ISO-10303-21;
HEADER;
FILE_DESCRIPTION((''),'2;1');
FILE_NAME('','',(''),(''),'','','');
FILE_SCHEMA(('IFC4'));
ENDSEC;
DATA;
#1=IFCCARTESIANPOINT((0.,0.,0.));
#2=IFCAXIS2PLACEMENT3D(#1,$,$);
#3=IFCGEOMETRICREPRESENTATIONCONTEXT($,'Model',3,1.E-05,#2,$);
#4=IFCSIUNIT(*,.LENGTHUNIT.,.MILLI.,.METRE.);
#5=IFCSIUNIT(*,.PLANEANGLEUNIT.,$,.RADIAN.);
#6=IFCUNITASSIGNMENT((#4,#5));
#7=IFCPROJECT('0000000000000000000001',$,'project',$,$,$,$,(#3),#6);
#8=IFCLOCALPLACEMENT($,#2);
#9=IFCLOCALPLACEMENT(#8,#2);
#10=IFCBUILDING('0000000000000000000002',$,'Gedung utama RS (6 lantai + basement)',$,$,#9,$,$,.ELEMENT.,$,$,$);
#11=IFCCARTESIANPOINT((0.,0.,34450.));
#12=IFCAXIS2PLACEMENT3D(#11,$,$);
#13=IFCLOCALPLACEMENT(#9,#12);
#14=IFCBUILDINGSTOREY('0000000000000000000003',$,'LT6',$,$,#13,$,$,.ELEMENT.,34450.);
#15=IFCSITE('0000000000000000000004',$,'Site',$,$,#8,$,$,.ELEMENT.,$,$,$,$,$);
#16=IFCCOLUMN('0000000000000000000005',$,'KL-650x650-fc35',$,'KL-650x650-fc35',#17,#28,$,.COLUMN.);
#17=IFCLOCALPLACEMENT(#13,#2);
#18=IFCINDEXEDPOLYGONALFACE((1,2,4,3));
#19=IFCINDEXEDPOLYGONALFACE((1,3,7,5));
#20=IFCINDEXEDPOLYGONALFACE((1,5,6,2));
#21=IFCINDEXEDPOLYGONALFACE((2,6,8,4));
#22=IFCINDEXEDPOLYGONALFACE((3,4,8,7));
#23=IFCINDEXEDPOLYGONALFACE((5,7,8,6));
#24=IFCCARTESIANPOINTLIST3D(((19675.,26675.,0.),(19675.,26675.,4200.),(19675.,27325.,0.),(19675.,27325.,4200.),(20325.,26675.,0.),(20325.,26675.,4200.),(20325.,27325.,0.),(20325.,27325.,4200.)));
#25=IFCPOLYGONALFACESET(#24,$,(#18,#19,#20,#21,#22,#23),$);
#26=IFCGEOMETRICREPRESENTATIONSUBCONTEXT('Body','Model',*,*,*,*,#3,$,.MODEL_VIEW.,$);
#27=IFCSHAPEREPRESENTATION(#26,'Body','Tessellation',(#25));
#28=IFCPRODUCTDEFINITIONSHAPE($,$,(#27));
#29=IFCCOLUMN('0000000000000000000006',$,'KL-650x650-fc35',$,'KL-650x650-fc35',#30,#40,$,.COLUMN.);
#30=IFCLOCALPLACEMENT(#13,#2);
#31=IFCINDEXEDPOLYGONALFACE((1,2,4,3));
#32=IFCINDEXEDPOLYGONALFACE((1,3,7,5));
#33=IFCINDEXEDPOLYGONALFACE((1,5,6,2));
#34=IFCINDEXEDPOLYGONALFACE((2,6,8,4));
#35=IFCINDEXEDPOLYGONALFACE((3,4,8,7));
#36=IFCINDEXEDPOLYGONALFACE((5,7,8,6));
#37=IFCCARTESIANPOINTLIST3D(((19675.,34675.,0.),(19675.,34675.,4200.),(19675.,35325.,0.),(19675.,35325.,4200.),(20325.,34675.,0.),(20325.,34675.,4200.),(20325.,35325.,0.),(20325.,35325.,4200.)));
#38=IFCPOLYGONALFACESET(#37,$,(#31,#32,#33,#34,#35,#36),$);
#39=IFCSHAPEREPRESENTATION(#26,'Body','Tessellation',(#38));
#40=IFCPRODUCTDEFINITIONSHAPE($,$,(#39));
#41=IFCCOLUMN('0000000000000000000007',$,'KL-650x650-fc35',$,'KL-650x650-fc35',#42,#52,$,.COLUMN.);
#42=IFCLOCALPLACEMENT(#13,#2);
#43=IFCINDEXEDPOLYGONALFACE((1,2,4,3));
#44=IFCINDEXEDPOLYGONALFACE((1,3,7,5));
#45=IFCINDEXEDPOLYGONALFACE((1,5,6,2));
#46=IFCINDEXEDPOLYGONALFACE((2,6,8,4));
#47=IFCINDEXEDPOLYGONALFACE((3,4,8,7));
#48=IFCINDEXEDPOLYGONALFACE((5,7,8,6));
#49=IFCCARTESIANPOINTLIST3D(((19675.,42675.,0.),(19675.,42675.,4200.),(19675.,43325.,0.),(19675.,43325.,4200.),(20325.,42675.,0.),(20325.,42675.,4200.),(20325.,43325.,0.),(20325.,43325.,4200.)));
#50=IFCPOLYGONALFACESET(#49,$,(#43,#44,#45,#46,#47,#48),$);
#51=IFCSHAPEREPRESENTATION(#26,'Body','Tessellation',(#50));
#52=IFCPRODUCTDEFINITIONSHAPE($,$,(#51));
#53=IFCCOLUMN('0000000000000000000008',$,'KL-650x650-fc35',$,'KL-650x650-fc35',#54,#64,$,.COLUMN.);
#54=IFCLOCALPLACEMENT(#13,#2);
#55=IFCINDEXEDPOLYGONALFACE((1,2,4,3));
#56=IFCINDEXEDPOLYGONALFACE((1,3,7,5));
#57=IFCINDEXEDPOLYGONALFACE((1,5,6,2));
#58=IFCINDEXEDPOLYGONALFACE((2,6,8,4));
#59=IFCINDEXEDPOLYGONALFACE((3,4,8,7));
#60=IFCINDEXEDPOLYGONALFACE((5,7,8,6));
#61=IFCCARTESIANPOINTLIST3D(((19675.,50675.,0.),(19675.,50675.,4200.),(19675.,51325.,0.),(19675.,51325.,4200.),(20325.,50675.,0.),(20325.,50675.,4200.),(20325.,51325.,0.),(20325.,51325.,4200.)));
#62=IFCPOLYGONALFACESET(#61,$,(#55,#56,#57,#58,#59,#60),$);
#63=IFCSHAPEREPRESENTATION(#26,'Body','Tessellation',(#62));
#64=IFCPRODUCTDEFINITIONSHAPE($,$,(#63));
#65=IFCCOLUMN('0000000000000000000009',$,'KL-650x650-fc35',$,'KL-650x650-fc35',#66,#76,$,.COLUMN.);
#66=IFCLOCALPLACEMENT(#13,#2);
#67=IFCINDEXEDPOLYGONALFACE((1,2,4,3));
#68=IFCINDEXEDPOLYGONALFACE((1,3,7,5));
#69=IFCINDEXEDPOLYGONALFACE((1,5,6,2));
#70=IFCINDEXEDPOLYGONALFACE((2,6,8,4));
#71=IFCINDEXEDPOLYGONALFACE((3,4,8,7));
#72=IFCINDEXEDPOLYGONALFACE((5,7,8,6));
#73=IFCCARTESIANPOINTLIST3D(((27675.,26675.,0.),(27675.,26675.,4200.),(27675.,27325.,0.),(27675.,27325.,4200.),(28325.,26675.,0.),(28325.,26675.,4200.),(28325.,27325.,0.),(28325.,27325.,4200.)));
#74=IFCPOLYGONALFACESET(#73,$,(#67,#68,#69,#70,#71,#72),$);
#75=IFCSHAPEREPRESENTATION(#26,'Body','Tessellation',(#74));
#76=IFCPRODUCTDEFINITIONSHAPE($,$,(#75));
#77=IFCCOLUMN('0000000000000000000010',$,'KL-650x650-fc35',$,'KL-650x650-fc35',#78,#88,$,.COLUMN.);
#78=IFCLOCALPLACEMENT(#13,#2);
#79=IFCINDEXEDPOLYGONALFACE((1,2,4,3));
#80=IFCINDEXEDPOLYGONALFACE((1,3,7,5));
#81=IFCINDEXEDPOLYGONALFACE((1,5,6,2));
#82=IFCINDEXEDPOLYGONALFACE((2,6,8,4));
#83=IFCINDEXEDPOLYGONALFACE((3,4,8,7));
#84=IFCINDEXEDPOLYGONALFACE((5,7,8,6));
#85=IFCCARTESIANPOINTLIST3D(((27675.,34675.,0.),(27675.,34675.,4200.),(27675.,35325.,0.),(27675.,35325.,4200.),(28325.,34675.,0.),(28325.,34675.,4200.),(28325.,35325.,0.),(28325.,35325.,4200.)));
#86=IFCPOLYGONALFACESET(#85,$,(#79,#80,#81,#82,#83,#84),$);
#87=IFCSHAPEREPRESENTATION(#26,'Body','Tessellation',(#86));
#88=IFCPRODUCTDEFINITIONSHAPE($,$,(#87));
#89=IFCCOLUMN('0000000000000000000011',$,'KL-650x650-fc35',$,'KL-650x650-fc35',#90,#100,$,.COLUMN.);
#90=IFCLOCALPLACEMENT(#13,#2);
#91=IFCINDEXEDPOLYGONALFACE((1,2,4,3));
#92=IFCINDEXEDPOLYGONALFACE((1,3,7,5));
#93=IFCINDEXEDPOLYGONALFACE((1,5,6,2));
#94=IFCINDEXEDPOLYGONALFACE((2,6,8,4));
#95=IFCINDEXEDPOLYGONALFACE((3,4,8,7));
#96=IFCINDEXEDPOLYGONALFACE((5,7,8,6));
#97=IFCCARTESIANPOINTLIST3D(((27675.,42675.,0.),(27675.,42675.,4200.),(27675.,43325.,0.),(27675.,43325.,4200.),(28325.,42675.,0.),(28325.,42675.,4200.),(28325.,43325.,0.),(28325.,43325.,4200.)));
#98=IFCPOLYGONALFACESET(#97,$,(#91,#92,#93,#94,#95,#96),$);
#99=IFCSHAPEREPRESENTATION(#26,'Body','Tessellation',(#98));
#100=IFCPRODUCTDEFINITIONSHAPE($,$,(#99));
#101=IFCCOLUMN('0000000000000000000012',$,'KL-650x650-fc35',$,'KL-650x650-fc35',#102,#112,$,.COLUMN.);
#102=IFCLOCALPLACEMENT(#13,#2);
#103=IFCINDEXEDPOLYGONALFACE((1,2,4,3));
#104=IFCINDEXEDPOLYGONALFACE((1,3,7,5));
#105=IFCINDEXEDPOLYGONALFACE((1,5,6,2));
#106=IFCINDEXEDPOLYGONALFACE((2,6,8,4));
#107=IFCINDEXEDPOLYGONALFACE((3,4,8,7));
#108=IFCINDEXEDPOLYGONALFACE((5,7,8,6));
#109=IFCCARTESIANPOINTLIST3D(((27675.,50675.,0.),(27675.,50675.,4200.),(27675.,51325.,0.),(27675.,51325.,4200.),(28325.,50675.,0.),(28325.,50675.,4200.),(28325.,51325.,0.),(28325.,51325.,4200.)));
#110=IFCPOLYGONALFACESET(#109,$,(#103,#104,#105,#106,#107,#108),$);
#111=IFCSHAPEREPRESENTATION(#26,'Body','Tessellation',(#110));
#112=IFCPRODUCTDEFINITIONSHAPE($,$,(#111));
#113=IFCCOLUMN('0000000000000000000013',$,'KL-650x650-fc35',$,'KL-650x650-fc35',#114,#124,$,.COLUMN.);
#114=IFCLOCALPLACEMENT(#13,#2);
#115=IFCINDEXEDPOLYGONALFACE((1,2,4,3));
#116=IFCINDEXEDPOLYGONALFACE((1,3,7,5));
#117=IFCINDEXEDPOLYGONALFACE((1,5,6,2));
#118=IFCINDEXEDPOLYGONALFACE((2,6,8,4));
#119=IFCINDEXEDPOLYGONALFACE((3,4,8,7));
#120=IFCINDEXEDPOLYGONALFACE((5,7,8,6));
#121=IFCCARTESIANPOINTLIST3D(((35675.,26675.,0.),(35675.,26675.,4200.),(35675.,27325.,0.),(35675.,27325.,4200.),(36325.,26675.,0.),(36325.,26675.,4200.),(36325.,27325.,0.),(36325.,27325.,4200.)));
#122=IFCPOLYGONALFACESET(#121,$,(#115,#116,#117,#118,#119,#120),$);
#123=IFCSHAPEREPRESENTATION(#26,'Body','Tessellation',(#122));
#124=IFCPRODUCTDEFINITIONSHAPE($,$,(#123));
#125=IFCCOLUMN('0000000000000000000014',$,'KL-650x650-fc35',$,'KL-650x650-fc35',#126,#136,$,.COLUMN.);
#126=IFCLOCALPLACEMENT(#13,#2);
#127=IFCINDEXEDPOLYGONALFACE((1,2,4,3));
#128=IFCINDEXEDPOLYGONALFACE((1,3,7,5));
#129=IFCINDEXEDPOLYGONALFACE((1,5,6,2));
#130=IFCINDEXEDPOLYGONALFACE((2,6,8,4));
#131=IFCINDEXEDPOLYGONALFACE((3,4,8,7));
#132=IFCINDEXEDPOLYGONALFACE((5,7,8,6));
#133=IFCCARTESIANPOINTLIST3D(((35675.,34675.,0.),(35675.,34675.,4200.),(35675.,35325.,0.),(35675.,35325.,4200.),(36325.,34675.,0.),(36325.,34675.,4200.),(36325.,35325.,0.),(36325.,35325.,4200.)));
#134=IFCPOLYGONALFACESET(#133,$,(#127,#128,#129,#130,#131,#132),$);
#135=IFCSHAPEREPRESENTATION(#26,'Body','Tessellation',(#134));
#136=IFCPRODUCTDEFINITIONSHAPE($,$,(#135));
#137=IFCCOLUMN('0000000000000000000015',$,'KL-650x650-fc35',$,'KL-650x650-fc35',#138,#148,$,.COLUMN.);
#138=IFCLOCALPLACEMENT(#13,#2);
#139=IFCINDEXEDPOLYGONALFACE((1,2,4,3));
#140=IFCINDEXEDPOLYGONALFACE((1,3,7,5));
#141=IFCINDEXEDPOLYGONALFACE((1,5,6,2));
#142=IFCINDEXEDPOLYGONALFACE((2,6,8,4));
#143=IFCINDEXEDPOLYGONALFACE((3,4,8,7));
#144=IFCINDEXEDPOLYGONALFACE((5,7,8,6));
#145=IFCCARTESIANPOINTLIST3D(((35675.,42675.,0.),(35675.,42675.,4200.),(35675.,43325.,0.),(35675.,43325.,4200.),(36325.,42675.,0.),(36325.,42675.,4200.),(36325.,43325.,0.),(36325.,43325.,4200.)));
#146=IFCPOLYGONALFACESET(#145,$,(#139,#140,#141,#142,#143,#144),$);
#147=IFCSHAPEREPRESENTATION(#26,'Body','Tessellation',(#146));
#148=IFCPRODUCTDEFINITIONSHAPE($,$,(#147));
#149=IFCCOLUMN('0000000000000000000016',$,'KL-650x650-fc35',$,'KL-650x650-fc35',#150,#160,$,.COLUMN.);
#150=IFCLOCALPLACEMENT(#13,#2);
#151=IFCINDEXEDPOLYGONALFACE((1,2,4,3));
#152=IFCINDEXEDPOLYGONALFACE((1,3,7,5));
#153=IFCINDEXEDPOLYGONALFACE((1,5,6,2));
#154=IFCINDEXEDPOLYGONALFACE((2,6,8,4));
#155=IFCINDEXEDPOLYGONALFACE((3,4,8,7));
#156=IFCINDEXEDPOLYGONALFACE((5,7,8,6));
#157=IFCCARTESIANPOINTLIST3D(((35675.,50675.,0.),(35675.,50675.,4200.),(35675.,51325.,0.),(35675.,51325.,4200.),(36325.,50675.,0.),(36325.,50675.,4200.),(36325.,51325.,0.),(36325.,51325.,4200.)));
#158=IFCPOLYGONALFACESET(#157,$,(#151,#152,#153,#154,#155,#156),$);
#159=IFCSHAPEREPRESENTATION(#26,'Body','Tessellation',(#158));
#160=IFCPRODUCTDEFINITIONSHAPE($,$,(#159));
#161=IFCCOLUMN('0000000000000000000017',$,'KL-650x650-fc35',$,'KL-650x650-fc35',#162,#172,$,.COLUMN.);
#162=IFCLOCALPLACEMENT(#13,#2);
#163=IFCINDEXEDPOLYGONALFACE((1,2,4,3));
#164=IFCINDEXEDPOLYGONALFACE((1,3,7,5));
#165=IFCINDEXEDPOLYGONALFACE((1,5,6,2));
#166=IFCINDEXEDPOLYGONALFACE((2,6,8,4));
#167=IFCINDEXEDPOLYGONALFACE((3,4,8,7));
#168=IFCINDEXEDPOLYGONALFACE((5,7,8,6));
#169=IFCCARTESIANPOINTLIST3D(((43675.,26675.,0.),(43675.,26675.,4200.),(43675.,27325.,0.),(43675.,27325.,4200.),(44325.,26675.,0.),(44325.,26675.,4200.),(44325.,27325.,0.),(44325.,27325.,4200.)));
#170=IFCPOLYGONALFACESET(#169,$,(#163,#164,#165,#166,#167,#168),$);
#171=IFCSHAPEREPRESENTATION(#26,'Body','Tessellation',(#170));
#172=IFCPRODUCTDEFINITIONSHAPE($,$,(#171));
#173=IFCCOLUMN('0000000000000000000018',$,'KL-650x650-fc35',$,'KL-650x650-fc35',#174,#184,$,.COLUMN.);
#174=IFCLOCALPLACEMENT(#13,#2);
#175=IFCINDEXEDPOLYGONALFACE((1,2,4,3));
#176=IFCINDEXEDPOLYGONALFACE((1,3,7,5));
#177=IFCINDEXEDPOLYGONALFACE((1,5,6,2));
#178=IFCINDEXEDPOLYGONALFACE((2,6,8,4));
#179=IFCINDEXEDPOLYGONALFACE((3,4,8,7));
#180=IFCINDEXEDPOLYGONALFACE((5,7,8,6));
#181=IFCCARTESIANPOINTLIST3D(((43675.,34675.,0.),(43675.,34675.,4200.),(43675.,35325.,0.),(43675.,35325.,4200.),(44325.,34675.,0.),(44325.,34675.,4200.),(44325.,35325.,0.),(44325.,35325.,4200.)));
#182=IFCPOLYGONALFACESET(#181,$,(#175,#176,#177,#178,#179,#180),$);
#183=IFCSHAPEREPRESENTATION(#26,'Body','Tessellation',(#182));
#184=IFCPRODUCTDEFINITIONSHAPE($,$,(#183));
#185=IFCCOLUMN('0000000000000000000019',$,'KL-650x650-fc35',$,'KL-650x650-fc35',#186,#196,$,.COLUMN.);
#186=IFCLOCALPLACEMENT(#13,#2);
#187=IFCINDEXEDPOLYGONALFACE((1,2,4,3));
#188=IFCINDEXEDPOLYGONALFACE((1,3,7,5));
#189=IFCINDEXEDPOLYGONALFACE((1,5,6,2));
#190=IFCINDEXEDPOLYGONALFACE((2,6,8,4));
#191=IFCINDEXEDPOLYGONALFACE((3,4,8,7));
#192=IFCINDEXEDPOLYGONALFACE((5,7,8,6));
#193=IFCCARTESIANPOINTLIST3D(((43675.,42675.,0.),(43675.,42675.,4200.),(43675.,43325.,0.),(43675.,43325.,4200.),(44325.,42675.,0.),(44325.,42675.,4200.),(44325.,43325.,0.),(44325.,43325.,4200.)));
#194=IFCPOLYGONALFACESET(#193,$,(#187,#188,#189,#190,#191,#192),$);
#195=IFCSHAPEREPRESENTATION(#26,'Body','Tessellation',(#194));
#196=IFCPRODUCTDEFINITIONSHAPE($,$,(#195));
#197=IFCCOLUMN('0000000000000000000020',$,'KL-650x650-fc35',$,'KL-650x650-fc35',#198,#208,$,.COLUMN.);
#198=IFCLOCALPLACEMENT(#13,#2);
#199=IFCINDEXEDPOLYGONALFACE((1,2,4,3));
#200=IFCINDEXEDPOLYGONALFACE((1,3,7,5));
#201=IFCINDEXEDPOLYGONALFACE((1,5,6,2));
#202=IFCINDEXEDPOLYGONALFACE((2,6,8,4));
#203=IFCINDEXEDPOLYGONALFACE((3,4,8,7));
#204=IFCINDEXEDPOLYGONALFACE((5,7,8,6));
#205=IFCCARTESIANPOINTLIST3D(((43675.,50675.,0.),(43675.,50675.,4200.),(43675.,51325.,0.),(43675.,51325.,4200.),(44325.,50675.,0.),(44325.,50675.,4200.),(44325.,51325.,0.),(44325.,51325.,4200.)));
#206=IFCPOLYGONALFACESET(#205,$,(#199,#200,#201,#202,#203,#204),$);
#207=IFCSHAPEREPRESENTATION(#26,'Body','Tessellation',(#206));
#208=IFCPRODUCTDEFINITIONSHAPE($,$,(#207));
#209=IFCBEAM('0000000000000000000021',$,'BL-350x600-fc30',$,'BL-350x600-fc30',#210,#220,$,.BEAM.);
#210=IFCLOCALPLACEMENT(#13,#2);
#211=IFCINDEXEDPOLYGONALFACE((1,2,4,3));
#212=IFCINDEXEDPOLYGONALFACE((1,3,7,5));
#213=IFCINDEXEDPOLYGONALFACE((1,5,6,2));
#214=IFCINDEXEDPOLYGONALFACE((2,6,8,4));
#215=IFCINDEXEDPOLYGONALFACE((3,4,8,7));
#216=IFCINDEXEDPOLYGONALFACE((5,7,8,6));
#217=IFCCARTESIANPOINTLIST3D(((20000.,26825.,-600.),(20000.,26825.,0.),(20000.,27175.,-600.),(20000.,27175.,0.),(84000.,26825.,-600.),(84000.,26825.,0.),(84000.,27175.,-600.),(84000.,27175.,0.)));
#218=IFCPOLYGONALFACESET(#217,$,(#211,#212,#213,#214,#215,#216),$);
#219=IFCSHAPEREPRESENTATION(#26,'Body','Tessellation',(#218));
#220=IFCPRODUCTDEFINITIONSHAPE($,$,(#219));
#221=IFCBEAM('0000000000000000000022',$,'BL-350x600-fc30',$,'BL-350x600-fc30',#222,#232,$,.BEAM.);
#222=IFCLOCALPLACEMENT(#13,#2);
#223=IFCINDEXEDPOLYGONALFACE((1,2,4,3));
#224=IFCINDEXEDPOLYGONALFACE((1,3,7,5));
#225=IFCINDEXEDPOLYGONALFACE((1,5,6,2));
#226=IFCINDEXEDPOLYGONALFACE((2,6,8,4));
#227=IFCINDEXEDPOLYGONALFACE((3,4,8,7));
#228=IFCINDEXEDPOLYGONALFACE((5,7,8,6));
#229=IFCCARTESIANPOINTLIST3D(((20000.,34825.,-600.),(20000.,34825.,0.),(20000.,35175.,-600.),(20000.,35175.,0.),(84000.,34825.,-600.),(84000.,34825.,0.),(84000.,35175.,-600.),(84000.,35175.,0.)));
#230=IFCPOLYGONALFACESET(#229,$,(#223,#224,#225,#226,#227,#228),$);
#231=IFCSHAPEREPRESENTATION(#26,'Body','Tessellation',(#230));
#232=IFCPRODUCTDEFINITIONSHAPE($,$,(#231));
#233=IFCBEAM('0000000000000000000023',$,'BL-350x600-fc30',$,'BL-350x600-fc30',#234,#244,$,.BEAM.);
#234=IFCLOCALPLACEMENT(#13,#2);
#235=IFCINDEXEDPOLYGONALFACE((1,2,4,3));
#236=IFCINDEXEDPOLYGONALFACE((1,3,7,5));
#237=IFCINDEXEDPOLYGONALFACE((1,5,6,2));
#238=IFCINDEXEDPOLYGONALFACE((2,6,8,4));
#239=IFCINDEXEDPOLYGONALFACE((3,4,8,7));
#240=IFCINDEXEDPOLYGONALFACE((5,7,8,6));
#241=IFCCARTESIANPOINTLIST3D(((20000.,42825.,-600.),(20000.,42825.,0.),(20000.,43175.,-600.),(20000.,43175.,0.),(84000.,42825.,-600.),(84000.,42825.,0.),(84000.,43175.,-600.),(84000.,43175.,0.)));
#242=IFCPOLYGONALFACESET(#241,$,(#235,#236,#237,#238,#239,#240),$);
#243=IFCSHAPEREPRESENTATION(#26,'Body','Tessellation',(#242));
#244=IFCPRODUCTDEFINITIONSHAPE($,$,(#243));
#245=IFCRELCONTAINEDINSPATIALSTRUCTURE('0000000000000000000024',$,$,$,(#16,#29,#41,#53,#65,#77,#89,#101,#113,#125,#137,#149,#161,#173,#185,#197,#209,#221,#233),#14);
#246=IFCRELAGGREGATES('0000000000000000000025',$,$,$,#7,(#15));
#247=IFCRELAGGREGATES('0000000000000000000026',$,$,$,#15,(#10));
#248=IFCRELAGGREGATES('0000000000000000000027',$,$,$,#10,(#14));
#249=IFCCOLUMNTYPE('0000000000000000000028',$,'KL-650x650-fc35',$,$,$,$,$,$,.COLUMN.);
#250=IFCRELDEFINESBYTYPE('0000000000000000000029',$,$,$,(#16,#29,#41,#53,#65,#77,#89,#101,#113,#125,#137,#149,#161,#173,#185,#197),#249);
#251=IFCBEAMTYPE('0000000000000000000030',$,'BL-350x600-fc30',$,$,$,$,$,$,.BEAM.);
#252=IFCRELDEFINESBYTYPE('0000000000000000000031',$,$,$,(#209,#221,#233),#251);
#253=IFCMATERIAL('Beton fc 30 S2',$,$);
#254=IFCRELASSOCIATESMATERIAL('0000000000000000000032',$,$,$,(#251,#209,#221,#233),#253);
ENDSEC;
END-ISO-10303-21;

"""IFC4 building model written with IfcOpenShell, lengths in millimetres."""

from ifc_helpers import new_model, si_unit, frame, origin, origin_2d, place, context, subcontext, project, spatial, rectangle, extrude, material, material_profile, profile_set, profile_usage, type_object, element, save


model = new_model("IFC4")

# Units and contexts
model_context = context("Model", 3, precision=1e-05, world=origin())
body_context = subcontext(model_context, "Body", "Model", "MODEL_VIEW")
ifc_project = project(units=[si_unit("LENGTHUNIT", "METRE", prefix="MILLI"), si_unit("PLANEANGLEUNIT", "RADIAN")], contexts=[model_context])

# Site, building, storey
site_placement = place(None, origin())
site = spatial("IfcSite", under=ifc_project, at=site_placement, Name="Site", CompositionType="ELEMENT")
building_placement = place(site_placement, origin())
building = spatial("IfcBuilding", under=site, at=building_placement, Name="Gedung utama RS (6 lantai + basement)", CompositionType="ELEMENT")
storey_placement = place(building_placement, frame((0.0, 0.0, 34450.0)))
storey = spatial("IfcBuildingStorey", under=building, at=storey_placement, Name="LT6", CompositionType="ELEMENT", Elevation=34450.0)

# Columns
ifc_material_profile_1 = material_profile(None, rectangle(XDim=650.0, YDim=650.0, at=origin_2d()), Name="KL-650x650-fc35")
ifc_profile_set_1 = profile_set([ifc_material_profile_1], Name="KL-650x650-fc35")
ifc_profile_usage_1 = profile_usage(ifc_profile_set_1, cardinal=5)
column_type = type_object("IfcColumnType", Name="KL-650x650-fc35", PredefinedType="COLUMN", material=ifc_profile_set_1)
for number, where, z_axis, x_axis, name in (
    (1, (20000.0, 27000.0, 0.0), (0.0, 0.0, 1.0), (1.0, 0.0, 0.0), "KL-650x650-fc35"),
    (2, (20000.0, 35000.0, 0.0), (0.0, 0.0, 1.0), (1.0, 0.0, 0.0), "KL-650x650-fc35"),
    (3, (20000.0, 43000.0, 0.0), (0.0, 0.0, 1.0), (1.0, 0.0, 0.0), "KL-650x650-fc35"),
    (4, (20000.0, 51000.0, 0.0), (0.0, 0.0, 1.0), (1.0, 0.0, 0.0), "KL-650x650-fc35"),
    (5, (28000.0, 27000.0, 0.0), (0.0, 0.0, 1.0), (1.0, 0.0, 0.0), "KL-650x650-fc35"),
    (6, (28000.0, 35000.0, 0.0), (0.0, 0.0, 1.0), (1.0, 0.0, 0.0), "KL-650x650-fc35"),
    (7, (28000.0, 43000.0, 0.0), (0.0, 0.0, 1.0), (1.0, 0.0, 0.0), "KL-650x650-fc35"),
    (8, (28000.0, 51000.0, 0.0), (0.0, 0.0, 1.0), (1.0, 0.0, 0.0), "KL-650x650-fc35"),
    (9, (36000.0, 27000.0, 0.0), (0.0, 0.0, 1.0), (1.0, 0.0, 0.0), "KL-650x650-fc35"),
    (10, (36000.0, 35000.0, 0.0), (0.0, 0.0, 1.0), (1.0, 0.0, 0.0), "KL-650x650-fc35"),
    (11, (36000.0, 43000.0, 0.0), (0.0, 0.0, 1.0), (1.0, 0.0, 0.0), "KL-650x650-fc35"),
    (12, (36000.0, 51000.0, 0.0), (0.0, 0.0, 1.0), (1.0, 0.0, 0.0), "KL-650x650-fc35"),
    (13, (44000.0, 27000.0, 0.0), (0.0, 0.0, 1.0), (1.0, 0.0, 0.0), "KL-650x650-fc35"),
    (14, (44000.0, 35000.0, 0.0), (0.0, 0.0, 1.0), (1.0, 0.0, 0.0), "KL-650x650-fc35"),
    (15, (44000.0, 43000.0, 0.0), (0.0, 0.0, 1.0), (1.0, 0.0, 0.0), "KL-650x650-fc35"),
    (16, (44000.0, 51000.0, 0.0), (0.0, 0.0, 1.0), (1.0, 0.0, 0.0), "KL-650x650-fc35"),
):
    element("IfcColumn", number, at=place(storey_placement, frame(where, z_axis=z_axis, x_axis=x_axis)), inside=storey, type_object=column_type, material=ifc_profile_usage_1, Name=name, ObjectType="KL-650x650-fc35", PredefinedType="COLUMN", context=body_context, shape_type="SweptSolid", body=[
        extrude(rectangle(XDim=650.0, YDim=650.0, at=origin_2d()), origin(), (0.0, 0.0, 1.0), 4200.0),
    ])

# Beams
ifc_material = material(Name="Beton fc 30 S2")
ifc_material_profile_2 = material_profile(ifc_material, rectangle(XDim=350.0, YDim=600.0, at=origin_2d()), Name="BL-350x600-fc30")
ifc_profile_set_2 = profile_set([ifc_material_profile_2], Name="BL-350x600-fc30")
ifc_profile_usage_2 = profile_usage(ifc_profile_set_2, cardinal=8)
beam_type = type_object("IfcBeamType", Name="BL-350x600-fc30", PredefinedType="BEAM", material=ifc_profile_set_2)
for number, where, name in (
    (17, (20000.0, 27000.0, -300.0), "BL-350x600-fc30"),
    (18, (20000.0, 35000.0, -300.0), "BL-350x600-fc30"),
    (19, (20000.0, 43000.0, -300.0), "BL-350x600-fc30"),
):
    element("IfcBeam", number, at=place(storey_placement, frame(where)), inside=storey, type_object=beam_type, material=ifc_profile_usage_2, Name=name, ObjectType="BL-350x600-fc30", PredefinedType="BEAM", context=body_context, shape_type="SweptSolid", body=[
        extrude(rectangle(XDim=350.0, YDim=600.0, at=origin_2d()), frame((0.0, 0.0, 0.0), z_axis=(1.0, 0.0, 0.0), x_axis=(0.0, 1.0, 0.0)), (0.0, 0.0, 1.0), 64000.0),
    ])

save(model, "model.ifc")
